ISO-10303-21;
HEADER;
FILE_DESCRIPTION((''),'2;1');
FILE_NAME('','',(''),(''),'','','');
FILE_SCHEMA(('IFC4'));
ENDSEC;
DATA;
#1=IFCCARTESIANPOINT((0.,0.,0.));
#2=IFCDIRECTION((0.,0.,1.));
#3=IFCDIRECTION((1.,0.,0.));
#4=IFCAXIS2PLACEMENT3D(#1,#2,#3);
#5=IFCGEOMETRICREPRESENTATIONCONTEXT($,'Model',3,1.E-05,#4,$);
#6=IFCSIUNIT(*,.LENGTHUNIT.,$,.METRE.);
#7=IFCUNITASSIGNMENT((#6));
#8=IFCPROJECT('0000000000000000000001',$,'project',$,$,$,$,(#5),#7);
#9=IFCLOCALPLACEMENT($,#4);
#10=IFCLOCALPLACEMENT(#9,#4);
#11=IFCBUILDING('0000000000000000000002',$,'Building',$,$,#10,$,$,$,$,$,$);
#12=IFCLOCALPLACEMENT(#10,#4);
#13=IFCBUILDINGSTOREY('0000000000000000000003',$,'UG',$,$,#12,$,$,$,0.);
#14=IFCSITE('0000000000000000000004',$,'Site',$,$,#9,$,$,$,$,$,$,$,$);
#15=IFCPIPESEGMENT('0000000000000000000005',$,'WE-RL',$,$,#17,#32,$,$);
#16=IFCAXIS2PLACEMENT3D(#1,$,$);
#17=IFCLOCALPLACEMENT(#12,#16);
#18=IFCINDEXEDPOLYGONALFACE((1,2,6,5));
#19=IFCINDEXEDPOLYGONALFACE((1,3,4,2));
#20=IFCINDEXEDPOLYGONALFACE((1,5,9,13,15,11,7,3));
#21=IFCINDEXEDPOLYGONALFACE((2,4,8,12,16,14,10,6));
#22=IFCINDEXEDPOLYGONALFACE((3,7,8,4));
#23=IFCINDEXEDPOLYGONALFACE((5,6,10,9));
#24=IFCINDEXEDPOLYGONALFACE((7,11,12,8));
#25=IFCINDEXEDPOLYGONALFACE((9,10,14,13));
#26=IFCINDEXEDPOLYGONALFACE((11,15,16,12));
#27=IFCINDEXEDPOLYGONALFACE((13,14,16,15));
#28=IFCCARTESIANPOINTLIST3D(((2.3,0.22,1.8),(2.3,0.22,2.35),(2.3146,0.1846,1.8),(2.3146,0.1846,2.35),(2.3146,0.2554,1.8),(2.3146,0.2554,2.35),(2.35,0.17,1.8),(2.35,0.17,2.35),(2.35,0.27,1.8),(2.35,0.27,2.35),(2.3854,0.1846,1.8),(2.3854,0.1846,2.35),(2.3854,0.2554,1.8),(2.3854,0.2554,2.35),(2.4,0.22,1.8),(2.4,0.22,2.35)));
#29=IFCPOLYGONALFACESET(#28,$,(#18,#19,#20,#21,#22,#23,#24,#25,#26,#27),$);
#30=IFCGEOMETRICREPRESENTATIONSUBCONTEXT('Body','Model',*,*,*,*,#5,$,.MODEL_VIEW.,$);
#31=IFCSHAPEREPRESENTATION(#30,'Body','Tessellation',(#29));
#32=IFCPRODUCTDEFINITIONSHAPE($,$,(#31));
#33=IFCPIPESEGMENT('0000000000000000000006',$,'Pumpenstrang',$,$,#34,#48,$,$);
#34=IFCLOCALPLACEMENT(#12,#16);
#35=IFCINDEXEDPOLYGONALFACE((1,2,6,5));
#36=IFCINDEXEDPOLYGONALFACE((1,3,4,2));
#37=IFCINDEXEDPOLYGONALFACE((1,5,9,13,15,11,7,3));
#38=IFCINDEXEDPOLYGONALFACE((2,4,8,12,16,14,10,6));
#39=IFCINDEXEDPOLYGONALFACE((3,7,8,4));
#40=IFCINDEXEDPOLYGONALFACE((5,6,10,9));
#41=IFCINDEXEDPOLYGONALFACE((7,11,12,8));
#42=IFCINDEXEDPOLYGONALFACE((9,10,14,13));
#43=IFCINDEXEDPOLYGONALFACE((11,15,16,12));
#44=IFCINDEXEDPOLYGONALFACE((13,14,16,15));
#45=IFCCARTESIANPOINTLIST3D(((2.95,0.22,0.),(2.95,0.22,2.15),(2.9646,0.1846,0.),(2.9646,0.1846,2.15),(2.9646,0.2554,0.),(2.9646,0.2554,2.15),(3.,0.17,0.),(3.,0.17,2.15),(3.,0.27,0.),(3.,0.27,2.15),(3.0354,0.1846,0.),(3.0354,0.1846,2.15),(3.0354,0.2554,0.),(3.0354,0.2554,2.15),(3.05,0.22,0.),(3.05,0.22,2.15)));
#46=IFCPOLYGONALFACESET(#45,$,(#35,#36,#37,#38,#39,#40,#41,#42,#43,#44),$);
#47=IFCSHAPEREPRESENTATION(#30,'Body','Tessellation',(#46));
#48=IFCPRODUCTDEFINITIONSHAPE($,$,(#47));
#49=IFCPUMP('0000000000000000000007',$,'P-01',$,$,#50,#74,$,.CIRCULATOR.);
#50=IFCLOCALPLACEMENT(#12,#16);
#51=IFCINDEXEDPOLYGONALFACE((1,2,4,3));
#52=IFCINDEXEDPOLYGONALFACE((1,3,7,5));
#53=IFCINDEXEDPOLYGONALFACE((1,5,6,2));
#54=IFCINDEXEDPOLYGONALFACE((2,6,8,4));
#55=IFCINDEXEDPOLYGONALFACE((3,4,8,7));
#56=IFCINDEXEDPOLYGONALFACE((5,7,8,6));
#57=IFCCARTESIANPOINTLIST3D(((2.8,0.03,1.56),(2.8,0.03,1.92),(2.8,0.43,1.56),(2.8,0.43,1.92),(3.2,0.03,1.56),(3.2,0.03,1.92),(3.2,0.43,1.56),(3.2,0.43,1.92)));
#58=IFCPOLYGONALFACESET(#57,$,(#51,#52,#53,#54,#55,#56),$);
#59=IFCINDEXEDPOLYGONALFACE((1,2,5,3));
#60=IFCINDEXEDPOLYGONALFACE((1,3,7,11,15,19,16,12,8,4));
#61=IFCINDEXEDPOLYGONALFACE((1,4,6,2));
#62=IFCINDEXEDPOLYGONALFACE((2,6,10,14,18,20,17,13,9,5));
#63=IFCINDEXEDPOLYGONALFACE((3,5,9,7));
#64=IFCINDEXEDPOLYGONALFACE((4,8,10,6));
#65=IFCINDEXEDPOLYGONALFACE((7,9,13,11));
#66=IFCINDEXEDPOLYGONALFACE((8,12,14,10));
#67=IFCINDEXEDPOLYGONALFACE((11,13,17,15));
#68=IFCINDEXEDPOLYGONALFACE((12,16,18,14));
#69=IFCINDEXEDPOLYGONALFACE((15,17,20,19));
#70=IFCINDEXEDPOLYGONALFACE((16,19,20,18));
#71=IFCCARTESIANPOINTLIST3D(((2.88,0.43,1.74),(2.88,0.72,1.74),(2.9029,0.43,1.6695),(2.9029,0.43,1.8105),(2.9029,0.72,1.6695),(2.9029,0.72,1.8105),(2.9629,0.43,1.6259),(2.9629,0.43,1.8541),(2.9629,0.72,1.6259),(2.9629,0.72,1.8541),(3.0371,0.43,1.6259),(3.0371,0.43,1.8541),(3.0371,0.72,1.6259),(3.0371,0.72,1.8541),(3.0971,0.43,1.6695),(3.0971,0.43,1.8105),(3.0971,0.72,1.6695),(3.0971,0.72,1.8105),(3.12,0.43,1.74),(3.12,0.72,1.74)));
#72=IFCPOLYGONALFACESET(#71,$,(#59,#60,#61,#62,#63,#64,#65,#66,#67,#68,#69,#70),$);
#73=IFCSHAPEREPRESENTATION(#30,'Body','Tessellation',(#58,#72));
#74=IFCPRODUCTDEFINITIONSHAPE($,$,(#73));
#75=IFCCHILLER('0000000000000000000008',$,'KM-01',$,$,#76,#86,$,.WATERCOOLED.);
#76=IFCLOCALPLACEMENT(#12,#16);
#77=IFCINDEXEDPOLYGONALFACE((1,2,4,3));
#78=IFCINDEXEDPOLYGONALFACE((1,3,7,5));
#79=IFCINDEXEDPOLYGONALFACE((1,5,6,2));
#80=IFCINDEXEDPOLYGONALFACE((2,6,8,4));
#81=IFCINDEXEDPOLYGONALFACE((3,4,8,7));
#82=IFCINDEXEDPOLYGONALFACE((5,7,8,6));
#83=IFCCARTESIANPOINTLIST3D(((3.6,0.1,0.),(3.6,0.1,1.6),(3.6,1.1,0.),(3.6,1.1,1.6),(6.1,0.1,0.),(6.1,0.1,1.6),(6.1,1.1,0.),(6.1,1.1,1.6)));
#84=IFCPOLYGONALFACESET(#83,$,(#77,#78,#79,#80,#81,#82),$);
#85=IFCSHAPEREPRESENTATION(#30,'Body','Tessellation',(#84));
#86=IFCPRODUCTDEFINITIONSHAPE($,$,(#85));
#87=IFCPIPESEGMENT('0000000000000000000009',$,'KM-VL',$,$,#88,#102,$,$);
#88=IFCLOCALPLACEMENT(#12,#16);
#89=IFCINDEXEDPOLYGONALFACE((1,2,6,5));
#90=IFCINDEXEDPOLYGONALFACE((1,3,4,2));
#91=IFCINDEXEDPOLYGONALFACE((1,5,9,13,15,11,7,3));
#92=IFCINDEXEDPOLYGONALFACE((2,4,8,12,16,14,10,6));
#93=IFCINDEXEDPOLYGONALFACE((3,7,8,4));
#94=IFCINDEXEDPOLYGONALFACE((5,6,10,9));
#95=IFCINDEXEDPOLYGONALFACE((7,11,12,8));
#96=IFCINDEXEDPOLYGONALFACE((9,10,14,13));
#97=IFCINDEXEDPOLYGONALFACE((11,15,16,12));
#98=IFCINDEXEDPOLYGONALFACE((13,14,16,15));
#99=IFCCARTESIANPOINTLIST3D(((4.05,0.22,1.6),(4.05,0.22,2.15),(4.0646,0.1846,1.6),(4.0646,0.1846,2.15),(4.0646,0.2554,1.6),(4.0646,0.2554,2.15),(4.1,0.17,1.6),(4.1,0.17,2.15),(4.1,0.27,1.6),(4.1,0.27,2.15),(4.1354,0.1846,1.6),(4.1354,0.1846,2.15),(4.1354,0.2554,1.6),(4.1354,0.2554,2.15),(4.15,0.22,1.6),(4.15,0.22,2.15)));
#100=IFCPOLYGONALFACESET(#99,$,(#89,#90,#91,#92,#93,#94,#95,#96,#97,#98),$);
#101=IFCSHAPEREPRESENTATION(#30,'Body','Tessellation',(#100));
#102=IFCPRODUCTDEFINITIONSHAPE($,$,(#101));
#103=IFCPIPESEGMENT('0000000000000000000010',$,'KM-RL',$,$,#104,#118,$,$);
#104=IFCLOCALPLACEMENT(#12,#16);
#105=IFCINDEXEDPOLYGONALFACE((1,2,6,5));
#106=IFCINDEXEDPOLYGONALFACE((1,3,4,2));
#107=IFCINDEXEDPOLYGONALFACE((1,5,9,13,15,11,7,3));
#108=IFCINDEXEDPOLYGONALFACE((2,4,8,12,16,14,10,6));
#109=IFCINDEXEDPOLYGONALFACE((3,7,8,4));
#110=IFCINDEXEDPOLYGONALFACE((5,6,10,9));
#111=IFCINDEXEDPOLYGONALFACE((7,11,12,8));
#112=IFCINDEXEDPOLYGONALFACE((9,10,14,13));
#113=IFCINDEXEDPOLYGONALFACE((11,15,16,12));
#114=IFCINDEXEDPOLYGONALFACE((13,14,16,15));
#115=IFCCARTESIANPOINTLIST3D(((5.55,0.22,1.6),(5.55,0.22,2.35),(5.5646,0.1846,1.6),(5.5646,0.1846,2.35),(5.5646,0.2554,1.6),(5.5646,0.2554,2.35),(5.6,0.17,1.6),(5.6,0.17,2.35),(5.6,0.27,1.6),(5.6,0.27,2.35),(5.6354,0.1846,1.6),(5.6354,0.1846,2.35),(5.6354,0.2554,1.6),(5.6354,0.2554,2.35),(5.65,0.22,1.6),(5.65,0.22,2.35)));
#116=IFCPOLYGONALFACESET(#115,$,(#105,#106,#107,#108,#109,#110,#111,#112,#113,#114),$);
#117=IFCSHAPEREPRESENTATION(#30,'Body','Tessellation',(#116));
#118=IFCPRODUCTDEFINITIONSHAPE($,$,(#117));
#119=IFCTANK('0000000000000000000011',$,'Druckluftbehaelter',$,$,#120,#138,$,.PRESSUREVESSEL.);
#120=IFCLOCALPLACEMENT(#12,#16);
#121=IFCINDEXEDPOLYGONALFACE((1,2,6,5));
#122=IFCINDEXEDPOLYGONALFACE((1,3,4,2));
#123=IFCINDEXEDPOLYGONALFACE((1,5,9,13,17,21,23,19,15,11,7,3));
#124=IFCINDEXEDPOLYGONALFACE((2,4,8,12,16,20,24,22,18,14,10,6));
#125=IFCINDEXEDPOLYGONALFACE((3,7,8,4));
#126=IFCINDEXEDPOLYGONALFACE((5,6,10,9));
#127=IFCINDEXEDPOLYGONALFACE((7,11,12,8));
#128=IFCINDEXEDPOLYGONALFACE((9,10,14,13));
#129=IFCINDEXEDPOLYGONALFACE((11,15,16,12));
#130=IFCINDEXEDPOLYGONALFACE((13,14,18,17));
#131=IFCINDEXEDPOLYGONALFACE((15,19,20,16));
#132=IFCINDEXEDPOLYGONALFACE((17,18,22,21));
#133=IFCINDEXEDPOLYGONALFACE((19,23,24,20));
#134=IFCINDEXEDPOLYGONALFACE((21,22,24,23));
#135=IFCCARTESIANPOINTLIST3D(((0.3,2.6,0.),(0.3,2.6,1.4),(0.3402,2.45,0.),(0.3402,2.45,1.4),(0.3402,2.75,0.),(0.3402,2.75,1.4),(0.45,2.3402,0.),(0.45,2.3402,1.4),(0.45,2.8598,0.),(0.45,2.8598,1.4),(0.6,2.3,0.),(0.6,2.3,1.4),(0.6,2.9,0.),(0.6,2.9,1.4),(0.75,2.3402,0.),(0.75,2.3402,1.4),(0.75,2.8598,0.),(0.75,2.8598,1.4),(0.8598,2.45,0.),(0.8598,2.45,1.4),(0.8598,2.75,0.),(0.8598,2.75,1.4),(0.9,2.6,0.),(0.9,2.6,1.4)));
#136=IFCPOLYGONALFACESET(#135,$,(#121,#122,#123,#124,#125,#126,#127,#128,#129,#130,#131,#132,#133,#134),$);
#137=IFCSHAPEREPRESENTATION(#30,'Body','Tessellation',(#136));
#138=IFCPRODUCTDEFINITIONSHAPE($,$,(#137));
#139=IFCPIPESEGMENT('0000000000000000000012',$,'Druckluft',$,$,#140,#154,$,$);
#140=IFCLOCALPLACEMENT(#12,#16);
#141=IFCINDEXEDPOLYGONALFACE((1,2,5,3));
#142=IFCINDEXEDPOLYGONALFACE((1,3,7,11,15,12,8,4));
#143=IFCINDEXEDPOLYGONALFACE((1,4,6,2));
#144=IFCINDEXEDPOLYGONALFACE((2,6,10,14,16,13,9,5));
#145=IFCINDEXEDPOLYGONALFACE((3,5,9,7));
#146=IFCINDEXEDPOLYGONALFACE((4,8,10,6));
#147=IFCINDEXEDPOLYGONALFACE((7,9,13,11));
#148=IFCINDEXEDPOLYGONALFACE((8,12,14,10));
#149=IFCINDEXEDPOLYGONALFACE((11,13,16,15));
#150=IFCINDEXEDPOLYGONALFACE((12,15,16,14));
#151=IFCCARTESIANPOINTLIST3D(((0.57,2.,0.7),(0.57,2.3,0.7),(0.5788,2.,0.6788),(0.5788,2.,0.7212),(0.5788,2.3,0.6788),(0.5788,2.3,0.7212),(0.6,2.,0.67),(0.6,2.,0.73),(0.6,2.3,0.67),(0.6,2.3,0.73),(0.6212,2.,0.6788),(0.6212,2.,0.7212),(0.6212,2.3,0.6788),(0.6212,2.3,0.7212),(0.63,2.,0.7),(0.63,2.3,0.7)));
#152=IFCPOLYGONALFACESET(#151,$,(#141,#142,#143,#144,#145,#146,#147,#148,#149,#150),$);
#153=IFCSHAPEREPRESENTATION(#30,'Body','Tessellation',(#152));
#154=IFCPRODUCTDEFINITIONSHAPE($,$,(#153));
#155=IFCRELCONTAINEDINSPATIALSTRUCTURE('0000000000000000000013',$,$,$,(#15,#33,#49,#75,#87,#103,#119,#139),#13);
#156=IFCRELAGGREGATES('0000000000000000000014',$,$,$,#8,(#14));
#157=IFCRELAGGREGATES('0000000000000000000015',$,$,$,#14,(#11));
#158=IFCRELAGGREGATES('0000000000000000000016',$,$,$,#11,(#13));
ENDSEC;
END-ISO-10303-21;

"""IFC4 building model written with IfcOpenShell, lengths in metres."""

from ifc_helpers import new_model, si_unit, frame, origin_with_axes, place, context, subcontext, project, spatial, polyline, outline, extrude, element, save


model = new_model("IFC4")

# Units and contexts
model_context = context("Model", 3, precision=1e-05, world=origin_with_axes())
body_context = subcontext(model_context, "Body", "Model", "MODEL_VIEW")
ifc_project = project(units=[si_unit("LENGTHUNIT", "METRE")], contexts=[model_context])

# Site, building, storey
site_placement = place(None, origin_with_axes())
site = spatial("IfcSite", under=ifc_project, at=site_placement, Name="Site")
building_placement = place(site_placement, origin_with_axes())
building = spatial("IfcBuilding", under=site, at=building_placement, Name="Building")
storey_placement = place(building_placement, origin_with_axes())
storey = spatial("IfcBuildingStorey", under=building, at=storey_placement, Name="UG", Elevation=0.0)

# Pipe segments
pipe_segment_1_placement = place(storey_placement, origin_with_axes())
element("IfcPipeSegment", 1, at=pipe_segment_1_placement, inside=storey, Name="WE-RL", context=body_context, shape_type="SweptSolid", body=[
    extrude(outline(polyline([(0.05, 0.0, 0.0), (0.0354, 0.0354, 0.0), (0.0, 0.05, 0.0), (-0.0354, 0.0354, 0.0), (-0.05, 0.0, 0.0), (-0.0354, -0.0354, 0.0), (0.0, -0.05, 0.0), (0.0354, -0.0354, 0.0), (0.05, 0.0, 0.0)])), frame((2.35, 0.22, 1.8), z_axis=(0.0, 0.0, 1.0), x_axis=(1.0, 0.0, 0.0)), (0.0, 0.0, 1.0), 0.55),
])
pipe_segment_2_placement = place(storey_placement, origin_with_axes())
element("IfcPipeSegment", 2, at=pipe_segment_2_placement, inside=storey, Name="Pumpenstrang", context=body_context, shape_type="SweptSolid", body=[
    extrude(outline(polyline([(0.05, 0.0, 0.0), (0.0354, 0.0354, 0.0), (0.0, 0.05, 0.0), (-0.0354, 0.0354, 0.0), (-0.05, 0.0, 0.0), (-0.0354, -0.0354, 0.0), (0.0, -0.05, 0.0), (0.0354, -0.0354, 0.0), (0.05, 0.0, 0.0)])), frame((3.0, 0.22, 0.0), z_axis=(0.0, 0.0, 1.0), x_axis=(1.0, 0.0, 0.0)), (0.0, 0.0, 1.0), 2.15),
])

# Pump
pump_placement = place(storey_placement, origin_with_axes())
element("IfcPump", 3, at=pump_placement, inside=storey, Name="P-01", PredefinedType="CIRCULATOR", context=body_context, shape_type="SweptSolid", body=[
    extrude(outline(polyline([(2.8, 0.03, 0.0), (3.2, 0.03, 0.0), (3.2, 0.43, 0.0), (2.8, 0.43, 0.0), (2.8, 0.03, 0.0)])), frame((0.0, 0.0, 1.56), z_axis=(0.0, 0.0, 1.0), x_axis=(1.0, 0.0, 0.0)), (0.0, 0.0, 1.0), 0.36),
    extrude(outline(polyline([(0.12, 0.0, 0.0), (0.0971, 0.0705, 0.0), (0.0371, 0.1141, 0.0), (-0.0371, 0.1141, 0.0), (-0.0971, 0.0705, 0.0), (-0.12, 0.0, 0.0), (-0.0971, -0.0705, 0.0), (-0.0371, -0.1141, 0.0), (0.0371, -0.1141, 0.0), (0.0971, -0.0705, 0.0), (0.12, 0.0, 0.0)])), frame((3.0, 0.43, 1.74), z_axis=(0.0, 1.0, 0.0), x_axis=(-1.0, 0.0, 0.0)), (0.0, 0.0, 1.0), 0.29),
])

# Chiller
chiller_placement = place(storey_placement, origin_with_axes())
element("IfcChiller", 4, at=chiller_placement, inside=storey, Name="KM-01", PredefinedType="WATERCOOLED", context=body_context, shape_type="SweptSolid", body=[
    extrude(outline(polyline([(3.6, 0.1, 0.0), (6.1, 0.1, 0.0), (6.1, 1.1, 0.0), (3.6, 1.1, 0.0), (3.6, 0.1, 0.0)])), origin_with_axes(), (0.0, 0.0, 1.0), 1.6),
])

# Pipe segments
pipe_segment_3_placement = place(storey_placement, origin_with_axes())
element("IfcPipeSegment", 5, at=pipe_segment_3_placement, inside=storey, Name="KM-VL", context=body_context, shape_type="SweptSolid", body=[
    extrude(outline(polyline([(0.05, 0.0, 0.0), (0.0354, 0.0354, 0.0), (0.0, 0.05, 0.0), (-0.0354, 0.0354, 0.0), (-0.05, 0.0, 0.0), (-0.0354, -0.0354, 0.0), (0.0, -0.05, 0.0), (0.0354, -0.0354, 0.0), (0.05, 0.0, 0.0)])), frame((4.1, 0.22, 1.6), z_axis=(0.0, 0.0, 1.0), x_axis=(1.0, 0.0, 0.0)), (0.0, 0.0, 1.0), 0.55),
])
pipe_segment_4_placement = place(storey_placement, origin_with_axes())
element("IfcPipeSegment", 6, at=pipe_segment_4_placement, inside=storey, Name="KM-RL", context=body_context, shape_type="SweptSolid", body=[
    extrude(outline(polyline([(0.05, 0.0, 0.0), (0.0354, 0.0354, 0.0), (0.0, 0.05, 0.0), (-0.0354, 0.0354, 0.0), (-0.05, 0.0, 0.0), (-0.0354, -0.0354, 0.0), (0.0, -0.05, 0.0), (0.0354, -0.0354, 0.0), (0.05, 0.0, 0.0)])), frame((5.6, 0.22, 1.6), z_axis=(0.0, 0.0, 1.0), x_axis=(1.0, 0.0, 0.0)), (0.0, 0.0, 1.0), 0.75),
])

# Tank
tank_1_placement = place(storey_placement, origin_with_axes())
element("IfcTank", 7, at=tank_1_placement, inside=storey, Name="Druckluftbehaelter", PredefinedType="PRESSUREVESSEL", context=body_context, shape_type="SweptSolid", body=[
    extrude(outline(polyline([(0.3, 0.0, 0.0), (0.2598, 0.15, 0.0), (0.15, 0.2598, 0.0), (0.0, 0.3, 0.0), (-0.15, 0.2598, 0.0), (-0.2598, 0.15, 0.0), (-0.3, 0.0, 0.0), (-0.2598, -0.15, 0.0), (-0.15, -0.2598, 0.0), (0.0, -0.3, 0.0), (0.15, -0.2598, 0.0), (0.2598, -0.15, 0.0), (0.3, 0.0, 0.0)])), frame((0.6, 2.6, 0.0), z_axis=(0.0, 0.0, 1.0), x_axis=(1.0, 0.0, 0.0)), (0.0, 0.0, 1.0), 1.4),
])

# Pipe segment
pipe_segment_5_placement = place(storey_placement, origin_with_axes())
element("IfcPipeSegment", 8, at=pipe_segment_5_placement, inside=storey, Name="Druckluft", context=body_context, shape_type="SweptSolid", body=[
    extrude(outline(polyline([(0.03, 0.0, 0.0), (0.0212, 0.0212, 0.0), (0.0, 0.03, 0.0), (-0.0212, 0.0212, 0.0), (-0.03, 0.0, 0.0), (-0.0212, -0.0212, 0.0), (0.0, -0.03, 0.0), (0.0212, -0.0212, 0.0), (0.03, 0.0, 0.0)])), frame((0.6, 2.0, 0.7), z_axis=(0.0, 1.0, 0.0), x_axis=(-1.0, 0.0, 0.0)), (0.0, 0.0, 1.0), 0.3),
])

save(model, "model.ifc")
